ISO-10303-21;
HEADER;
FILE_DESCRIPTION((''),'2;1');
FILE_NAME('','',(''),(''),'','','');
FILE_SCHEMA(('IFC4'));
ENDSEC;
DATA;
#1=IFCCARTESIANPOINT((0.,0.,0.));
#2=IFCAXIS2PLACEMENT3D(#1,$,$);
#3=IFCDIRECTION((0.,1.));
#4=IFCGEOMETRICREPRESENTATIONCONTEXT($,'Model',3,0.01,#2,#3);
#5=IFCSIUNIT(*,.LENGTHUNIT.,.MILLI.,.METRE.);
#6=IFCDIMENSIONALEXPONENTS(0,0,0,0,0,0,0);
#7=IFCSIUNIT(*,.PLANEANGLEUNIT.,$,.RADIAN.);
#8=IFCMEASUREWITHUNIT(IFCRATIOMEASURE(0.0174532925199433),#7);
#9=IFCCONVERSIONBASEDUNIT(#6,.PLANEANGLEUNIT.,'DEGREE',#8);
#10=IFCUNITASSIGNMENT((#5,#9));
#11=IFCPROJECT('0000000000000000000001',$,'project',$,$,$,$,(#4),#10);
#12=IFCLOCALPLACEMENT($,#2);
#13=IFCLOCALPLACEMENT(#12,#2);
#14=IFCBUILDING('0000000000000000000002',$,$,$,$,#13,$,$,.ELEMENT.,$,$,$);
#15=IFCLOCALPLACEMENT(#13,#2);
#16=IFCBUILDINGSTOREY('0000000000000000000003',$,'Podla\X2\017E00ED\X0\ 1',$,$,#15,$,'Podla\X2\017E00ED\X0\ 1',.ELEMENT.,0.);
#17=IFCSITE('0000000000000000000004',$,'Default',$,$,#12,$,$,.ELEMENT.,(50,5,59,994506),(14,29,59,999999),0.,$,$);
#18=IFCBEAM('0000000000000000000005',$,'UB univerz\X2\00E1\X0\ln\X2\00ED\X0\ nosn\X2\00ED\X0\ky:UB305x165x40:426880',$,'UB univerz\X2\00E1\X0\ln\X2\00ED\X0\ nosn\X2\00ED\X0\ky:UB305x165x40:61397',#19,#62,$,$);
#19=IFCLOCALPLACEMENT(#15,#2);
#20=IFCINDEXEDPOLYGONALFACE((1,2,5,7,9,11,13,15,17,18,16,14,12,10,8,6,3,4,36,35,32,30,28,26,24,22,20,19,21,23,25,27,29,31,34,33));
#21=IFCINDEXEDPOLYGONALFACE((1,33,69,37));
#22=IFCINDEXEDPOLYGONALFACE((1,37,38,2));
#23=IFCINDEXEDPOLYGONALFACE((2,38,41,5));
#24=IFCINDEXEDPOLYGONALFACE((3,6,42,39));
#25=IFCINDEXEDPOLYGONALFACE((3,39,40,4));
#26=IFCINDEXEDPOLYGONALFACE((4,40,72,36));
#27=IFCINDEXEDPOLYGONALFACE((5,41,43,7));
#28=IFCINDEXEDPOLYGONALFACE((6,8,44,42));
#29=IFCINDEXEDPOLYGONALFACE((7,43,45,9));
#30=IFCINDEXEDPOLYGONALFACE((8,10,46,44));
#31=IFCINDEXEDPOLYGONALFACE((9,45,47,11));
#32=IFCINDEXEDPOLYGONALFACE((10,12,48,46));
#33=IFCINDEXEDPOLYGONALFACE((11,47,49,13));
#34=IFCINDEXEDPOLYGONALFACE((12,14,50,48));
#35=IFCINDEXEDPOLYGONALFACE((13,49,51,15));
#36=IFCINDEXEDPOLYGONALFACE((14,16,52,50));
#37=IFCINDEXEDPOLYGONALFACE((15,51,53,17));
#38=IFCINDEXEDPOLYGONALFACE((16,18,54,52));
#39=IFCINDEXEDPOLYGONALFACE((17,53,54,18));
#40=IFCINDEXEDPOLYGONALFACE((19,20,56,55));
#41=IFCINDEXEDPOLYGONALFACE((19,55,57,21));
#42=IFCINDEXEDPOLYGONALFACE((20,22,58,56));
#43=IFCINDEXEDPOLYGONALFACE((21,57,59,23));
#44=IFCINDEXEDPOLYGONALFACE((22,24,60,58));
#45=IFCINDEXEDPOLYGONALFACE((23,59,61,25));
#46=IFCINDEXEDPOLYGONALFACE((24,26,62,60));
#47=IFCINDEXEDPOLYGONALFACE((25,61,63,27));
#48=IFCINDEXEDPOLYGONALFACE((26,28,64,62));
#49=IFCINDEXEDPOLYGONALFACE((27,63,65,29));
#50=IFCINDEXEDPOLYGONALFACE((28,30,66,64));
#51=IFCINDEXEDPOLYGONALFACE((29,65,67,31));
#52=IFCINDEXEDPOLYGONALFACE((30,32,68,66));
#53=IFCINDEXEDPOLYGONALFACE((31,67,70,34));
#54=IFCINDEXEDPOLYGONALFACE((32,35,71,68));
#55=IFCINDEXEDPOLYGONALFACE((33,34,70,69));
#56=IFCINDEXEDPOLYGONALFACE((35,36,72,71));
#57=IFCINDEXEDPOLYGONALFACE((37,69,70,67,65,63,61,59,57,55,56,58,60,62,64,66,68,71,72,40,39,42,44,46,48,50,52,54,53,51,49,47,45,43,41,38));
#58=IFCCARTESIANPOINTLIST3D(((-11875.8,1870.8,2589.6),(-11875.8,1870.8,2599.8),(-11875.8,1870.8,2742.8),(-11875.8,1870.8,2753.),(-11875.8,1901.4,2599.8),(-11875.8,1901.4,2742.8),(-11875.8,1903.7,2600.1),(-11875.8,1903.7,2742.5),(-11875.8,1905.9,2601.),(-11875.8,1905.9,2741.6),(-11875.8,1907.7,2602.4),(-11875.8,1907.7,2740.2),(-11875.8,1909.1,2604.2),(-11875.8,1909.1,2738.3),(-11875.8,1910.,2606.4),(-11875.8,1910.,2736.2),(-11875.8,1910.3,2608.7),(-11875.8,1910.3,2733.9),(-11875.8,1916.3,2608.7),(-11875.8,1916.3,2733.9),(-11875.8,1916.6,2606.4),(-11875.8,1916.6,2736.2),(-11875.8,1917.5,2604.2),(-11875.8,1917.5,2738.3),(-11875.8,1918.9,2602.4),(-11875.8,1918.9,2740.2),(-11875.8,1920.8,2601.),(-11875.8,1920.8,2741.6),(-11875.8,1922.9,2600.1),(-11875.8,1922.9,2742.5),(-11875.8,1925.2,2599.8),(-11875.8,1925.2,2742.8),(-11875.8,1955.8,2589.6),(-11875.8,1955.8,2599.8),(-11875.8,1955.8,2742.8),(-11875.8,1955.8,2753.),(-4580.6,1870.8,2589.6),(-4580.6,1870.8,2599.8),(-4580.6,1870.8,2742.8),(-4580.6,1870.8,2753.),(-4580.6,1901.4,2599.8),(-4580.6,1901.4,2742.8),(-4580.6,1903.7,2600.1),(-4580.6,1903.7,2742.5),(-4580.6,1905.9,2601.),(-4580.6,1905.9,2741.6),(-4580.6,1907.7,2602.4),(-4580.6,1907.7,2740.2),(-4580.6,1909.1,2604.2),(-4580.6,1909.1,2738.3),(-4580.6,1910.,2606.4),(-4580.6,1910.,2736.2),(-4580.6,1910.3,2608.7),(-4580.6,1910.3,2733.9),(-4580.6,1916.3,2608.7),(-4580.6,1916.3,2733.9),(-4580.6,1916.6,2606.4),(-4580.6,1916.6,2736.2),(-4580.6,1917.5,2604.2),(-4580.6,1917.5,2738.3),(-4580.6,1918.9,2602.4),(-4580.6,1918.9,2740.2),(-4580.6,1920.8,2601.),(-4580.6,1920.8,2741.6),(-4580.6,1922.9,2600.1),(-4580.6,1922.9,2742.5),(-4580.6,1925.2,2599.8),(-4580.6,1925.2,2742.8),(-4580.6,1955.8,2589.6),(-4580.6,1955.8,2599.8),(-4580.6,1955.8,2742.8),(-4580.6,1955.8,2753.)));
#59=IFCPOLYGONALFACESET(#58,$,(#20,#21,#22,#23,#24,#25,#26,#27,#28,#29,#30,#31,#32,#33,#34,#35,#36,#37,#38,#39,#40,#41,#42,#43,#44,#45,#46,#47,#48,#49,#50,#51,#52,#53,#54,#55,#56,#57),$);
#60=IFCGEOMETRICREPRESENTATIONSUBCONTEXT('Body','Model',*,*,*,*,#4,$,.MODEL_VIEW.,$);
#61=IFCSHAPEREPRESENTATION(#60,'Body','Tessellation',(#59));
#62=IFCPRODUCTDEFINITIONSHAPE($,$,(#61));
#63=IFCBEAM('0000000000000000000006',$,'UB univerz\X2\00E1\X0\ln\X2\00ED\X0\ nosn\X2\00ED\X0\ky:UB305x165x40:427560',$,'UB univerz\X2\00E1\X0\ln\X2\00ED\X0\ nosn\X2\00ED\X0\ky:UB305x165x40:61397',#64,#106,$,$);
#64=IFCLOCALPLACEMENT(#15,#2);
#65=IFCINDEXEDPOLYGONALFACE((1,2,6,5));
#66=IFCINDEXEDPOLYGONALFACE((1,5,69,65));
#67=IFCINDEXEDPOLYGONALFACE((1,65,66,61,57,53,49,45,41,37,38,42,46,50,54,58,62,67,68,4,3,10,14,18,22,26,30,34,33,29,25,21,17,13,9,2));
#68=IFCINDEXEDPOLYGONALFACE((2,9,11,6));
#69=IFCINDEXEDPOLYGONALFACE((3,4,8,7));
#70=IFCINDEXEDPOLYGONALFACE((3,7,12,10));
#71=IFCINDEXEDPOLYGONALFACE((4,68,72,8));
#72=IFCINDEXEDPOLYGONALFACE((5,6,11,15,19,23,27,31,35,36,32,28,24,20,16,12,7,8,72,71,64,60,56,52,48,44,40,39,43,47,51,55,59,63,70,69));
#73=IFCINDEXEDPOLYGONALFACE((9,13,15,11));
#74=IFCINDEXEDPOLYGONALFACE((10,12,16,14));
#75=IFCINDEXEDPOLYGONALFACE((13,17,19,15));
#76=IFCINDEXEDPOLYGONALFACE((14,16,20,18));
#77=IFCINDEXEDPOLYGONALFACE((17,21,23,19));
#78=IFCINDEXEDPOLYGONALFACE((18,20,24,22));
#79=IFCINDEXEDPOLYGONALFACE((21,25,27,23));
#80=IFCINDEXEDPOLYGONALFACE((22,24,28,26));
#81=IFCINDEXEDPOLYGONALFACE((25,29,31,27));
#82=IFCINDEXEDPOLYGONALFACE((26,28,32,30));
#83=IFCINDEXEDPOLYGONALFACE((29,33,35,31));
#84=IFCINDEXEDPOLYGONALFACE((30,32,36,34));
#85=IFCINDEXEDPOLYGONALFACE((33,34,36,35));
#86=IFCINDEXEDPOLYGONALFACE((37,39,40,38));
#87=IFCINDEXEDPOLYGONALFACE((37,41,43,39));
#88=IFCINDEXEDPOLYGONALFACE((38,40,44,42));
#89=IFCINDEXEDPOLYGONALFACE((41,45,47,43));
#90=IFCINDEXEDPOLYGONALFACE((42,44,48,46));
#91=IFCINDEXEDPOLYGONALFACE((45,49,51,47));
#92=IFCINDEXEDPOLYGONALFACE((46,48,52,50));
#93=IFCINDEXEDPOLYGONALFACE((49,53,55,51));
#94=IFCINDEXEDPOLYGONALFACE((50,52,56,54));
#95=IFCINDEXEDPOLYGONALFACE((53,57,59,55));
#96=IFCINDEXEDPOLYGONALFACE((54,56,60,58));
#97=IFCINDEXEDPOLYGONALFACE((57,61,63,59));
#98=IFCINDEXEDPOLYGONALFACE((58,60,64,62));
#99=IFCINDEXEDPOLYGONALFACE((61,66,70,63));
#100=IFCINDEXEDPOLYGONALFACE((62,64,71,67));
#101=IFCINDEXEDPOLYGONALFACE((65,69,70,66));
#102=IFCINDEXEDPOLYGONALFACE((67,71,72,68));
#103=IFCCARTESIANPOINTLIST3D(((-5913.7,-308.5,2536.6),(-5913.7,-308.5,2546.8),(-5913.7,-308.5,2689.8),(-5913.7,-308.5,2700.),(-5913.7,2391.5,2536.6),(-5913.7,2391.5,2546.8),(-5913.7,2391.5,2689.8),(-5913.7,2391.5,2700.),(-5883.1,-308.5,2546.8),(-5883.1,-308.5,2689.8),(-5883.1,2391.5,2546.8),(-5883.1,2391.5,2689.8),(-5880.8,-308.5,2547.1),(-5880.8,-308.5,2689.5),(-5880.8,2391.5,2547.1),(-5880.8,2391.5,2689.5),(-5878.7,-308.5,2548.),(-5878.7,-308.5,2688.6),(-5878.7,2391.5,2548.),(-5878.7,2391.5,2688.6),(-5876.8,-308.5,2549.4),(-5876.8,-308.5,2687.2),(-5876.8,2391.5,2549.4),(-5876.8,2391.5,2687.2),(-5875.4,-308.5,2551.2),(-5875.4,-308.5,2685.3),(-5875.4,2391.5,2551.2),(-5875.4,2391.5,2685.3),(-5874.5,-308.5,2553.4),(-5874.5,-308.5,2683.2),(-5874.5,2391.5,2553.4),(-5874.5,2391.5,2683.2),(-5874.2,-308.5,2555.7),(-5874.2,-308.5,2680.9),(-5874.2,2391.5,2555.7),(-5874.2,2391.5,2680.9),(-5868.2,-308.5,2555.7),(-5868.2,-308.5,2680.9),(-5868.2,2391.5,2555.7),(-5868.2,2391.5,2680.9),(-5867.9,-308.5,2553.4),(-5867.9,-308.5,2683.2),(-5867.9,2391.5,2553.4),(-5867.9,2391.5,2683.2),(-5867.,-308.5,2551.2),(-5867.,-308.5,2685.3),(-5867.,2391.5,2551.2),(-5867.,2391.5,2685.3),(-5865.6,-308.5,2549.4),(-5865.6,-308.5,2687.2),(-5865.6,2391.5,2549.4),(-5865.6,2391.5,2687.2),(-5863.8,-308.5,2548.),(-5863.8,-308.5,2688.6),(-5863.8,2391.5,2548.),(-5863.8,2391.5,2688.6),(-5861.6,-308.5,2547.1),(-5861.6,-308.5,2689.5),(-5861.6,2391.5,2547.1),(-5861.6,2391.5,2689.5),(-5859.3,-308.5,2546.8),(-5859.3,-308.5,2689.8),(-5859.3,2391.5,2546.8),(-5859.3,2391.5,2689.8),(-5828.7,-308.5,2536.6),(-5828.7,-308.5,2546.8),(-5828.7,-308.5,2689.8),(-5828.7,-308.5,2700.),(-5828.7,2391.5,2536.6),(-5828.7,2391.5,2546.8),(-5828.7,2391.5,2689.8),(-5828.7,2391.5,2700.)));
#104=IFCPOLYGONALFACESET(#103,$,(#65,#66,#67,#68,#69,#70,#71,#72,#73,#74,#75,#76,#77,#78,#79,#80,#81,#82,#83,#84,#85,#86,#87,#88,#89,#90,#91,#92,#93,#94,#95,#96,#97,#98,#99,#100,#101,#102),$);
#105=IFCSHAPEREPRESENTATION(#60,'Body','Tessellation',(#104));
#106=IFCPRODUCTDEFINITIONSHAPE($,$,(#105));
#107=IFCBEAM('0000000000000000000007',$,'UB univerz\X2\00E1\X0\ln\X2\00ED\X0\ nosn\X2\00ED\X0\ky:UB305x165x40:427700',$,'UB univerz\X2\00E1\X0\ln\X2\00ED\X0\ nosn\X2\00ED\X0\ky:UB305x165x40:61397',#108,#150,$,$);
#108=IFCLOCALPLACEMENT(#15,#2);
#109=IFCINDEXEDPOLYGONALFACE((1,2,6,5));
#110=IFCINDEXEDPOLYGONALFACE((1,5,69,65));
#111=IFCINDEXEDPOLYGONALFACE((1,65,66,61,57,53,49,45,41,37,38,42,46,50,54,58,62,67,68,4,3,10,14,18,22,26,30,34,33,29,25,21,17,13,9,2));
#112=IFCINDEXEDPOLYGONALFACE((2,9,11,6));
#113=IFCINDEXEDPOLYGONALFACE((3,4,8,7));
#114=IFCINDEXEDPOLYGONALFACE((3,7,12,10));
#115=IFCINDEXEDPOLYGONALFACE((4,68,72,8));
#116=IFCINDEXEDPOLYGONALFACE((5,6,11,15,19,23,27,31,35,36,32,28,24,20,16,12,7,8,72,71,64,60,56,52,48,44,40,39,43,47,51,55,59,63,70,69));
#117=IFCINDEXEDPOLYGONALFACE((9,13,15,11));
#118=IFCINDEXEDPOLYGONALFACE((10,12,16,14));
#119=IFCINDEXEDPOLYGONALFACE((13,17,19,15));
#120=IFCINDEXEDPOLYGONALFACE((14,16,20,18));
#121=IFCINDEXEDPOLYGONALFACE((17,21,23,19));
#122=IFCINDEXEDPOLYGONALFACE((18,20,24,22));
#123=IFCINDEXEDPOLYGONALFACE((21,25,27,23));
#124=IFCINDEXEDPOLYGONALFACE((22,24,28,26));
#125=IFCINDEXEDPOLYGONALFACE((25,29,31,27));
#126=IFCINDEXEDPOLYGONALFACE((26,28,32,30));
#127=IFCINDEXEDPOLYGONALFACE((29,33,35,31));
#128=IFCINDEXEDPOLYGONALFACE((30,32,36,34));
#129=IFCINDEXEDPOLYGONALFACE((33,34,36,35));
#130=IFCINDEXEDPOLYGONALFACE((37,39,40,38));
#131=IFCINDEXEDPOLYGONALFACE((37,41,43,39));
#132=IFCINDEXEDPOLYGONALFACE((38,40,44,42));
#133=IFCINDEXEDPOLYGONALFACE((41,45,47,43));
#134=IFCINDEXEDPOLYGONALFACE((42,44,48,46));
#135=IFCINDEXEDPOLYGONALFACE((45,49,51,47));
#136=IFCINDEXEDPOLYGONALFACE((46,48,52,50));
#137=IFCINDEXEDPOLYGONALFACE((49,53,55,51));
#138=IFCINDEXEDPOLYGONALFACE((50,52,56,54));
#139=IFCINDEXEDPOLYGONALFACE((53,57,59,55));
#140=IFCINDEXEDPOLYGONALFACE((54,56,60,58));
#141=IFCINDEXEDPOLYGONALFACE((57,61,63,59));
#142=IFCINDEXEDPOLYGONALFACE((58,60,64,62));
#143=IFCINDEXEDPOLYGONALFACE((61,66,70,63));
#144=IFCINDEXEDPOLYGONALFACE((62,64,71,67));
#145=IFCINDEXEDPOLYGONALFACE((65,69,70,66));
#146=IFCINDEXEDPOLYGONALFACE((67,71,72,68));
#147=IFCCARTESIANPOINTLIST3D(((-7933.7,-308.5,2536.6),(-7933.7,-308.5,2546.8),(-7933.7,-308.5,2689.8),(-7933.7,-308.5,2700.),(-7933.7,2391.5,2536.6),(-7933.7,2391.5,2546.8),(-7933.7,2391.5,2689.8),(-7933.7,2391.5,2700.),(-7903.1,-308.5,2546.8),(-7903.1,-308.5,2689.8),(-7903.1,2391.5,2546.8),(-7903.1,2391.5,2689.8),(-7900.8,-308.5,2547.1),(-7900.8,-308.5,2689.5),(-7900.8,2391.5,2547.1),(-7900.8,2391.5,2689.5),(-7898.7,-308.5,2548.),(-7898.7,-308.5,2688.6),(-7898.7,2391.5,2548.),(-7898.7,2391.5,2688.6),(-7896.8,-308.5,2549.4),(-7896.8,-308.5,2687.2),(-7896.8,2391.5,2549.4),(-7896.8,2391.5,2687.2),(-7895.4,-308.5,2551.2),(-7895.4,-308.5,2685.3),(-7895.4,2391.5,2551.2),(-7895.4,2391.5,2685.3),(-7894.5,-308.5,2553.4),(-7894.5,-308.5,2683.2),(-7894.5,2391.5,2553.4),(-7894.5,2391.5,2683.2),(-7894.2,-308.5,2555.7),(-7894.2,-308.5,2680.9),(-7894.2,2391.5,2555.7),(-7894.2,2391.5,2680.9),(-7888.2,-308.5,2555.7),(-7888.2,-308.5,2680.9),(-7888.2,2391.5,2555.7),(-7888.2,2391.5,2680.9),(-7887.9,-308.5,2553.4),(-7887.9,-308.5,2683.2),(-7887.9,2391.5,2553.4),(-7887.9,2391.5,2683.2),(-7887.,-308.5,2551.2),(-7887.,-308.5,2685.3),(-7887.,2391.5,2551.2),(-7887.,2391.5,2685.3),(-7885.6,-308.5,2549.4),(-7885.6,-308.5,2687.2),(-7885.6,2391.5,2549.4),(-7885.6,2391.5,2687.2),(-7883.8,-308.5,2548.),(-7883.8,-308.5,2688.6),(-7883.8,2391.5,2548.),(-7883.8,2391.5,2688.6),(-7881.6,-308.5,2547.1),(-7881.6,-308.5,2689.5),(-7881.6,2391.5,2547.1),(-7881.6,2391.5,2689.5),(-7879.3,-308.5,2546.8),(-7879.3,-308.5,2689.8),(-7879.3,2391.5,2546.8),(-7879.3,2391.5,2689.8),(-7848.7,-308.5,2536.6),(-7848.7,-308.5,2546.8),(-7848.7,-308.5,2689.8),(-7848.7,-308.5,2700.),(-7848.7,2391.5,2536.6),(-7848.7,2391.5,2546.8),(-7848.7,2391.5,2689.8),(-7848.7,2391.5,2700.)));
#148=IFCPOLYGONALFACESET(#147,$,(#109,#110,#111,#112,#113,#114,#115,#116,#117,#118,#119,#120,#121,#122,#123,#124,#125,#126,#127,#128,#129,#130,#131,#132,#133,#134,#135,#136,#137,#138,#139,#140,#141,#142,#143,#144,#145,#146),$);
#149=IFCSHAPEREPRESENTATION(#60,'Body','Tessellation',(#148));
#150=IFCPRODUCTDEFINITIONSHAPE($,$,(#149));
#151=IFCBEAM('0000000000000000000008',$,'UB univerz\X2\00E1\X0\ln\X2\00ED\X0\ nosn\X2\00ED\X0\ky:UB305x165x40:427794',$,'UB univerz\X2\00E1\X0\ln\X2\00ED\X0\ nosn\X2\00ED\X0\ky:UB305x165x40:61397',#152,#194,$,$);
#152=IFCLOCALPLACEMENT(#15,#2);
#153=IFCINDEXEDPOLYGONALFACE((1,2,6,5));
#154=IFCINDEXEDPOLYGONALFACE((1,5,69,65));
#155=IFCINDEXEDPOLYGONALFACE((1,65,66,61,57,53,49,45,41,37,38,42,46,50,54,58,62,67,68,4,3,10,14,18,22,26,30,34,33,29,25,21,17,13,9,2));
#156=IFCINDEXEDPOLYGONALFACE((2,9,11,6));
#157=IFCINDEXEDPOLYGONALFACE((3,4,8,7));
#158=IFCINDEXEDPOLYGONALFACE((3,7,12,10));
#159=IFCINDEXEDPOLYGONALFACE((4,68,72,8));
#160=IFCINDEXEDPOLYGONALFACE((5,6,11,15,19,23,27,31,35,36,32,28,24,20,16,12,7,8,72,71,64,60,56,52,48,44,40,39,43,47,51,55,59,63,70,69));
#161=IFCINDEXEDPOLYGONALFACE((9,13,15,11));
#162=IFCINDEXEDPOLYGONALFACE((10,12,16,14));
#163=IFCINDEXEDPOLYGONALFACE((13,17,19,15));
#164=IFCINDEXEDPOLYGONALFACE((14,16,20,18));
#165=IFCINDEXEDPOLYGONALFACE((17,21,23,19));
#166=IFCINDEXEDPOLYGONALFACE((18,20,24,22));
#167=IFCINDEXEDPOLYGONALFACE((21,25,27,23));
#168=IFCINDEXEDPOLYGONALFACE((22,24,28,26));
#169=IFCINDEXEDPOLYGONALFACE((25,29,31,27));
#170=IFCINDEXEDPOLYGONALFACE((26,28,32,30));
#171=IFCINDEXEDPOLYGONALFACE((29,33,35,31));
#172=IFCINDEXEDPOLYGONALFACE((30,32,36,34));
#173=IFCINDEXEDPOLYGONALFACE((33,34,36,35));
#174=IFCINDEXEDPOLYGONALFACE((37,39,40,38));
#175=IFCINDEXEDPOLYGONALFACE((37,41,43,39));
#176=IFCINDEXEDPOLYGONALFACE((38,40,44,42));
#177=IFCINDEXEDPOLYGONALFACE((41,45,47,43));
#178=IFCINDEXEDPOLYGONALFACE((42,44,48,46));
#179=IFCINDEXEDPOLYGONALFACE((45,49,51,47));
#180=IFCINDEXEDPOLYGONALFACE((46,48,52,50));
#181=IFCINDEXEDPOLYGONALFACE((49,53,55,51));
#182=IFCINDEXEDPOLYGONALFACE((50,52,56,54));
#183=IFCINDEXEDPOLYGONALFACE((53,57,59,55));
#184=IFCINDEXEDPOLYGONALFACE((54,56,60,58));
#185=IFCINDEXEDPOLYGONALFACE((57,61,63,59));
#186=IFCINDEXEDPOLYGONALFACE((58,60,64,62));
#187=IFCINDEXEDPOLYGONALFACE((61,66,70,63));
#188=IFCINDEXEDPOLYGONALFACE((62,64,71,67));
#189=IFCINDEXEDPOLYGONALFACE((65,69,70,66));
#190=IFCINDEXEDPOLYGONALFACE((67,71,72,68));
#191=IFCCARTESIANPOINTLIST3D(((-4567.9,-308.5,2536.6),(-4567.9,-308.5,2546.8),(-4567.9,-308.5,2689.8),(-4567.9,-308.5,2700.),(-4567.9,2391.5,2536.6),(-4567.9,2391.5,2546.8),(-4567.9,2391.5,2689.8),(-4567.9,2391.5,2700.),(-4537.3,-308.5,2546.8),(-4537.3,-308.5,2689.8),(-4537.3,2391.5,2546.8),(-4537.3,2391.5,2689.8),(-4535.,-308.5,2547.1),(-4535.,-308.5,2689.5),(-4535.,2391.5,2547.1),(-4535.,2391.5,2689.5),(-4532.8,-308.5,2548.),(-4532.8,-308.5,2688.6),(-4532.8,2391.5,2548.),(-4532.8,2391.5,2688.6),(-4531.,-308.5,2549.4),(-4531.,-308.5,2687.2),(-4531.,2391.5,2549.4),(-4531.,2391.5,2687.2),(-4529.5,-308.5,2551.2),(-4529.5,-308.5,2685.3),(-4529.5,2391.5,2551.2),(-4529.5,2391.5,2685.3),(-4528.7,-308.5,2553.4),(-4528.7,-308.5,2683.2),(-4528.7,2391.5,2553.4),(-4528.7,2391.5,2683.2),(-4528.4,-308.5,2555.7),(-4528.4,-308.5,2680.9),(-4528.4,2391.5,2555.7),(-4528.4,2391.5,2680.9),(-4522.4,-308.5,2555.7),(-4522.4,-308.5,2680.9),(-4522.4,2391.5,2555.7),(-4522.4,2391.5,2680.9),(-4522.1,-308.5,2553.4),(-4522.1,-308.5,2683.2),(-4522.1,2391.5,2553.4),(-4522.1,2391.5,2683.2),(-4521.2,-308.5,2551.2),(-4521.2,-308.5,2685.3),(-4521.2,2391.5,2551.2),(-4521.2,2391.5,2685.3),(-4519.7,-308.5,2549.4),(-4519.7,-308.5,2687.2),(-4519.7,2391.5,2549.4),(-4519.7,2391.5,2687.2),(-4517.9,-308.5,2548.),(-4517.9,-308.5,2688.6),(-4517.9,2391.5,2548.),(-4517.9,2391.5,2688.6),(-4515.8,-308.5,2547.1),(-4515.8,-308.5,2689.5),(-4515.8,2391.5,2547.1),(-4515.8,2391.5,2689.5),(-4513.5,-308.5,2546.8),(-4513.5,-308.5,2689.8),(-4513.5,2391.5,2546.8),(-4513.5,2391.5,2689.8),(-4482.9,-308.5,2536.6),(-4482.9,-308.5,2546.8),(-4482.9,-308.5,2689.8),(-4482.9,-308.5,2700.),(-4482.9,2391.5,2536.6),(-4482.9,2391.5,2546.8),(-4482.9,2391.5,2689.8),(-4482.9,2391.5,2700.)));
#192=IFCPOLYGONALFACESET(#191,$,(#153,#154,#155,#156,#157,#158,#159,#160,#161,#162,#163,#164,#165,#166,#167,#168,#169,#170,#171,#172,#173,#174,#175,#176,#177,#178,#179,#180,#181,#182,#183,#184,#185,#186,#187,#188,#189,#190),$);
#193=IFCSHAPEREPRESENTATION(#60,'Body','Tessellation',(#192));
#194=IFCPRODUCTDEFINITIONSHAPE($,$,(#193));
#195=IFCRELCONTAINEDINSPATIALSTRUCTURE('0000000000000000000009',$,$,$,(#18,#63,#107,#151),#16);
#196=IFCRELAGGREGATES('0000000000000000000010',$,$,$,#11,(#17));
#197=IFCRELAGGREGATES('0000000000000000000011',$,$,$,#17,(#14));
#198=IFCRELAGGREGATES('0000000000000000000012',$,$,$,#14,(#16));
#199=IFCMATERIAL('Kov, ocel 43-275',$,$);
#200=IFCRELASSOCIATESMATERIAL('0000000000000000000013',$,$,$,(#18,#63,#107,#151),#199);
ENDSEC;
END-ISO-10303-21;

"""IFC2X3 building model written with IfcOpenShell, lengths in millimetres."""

from ifc_helpers import new_model, entity, si_unit, converted_unit, direction, frame, frame_2d, origin, place, context, subcontext, project, spatial, i_section, extrude, material, element, save


model = new_model("IFC2X3")

# Units and contexts
model_context = context("Model", 3, precision=0.01, world=origin(), true_north=direction((0.0, 1.0)))
body_context = subcontext(model_context, "Body", "Model", "MODEL_VIEW")
ifc_project = project(units=[si_unit("LENGTHUNIT", "METRE", prefix="MILLI"), converted_unit("PLANEANGLEUNIT", "DEGREE", entity("IfcRatioMeasure", 0.0174532925199433), si_unit("PLANEANGLEUNIT", "RADIAN"), dimensions=[0, 0, 0, 0, 0, 0, 0])], contexts=[model_context])

# Site, building, storey
site_placement = place(None, origin())
site = spatial("IfcSite", under=ifc_project, at=site_placement, Name="Default", CompositionType="ELEMENT", RefLatitude=(50, 5, 59, 994506), RefLongitude=(14, 29, 59, 999999), RefElevation=0.0)
building_placement = place(site_placement, origin())
building = spatial("IfcBuilding", under=site, at=building_placement, CompositionType="ELEMENT")
storey_placement = place(building_placement, origin())
storey = spatial("IfcBuildingStorey", under=building, at=storey_placement, Name="Podlaží 1", LongName="Podlaží 1", CompositionType="ELEMENT", Elevation=0.0)

# Shared definitions
ifc_material = material(Name="Kov, ocel 43-275")

# Beams
beam_1_placement = place(storey_placement, frame((-4525.4, 1913.3, 0.0), z_axis=(0.0, 0.0, 1.0), x_axis=(-1.0, 0.0, 0.0)))
element("IfcBeam", 1, at=beam_1_placement, inside=storey, material=ifc_material, Name="UB univerzální nosníky:UB305x165x40:426880", ObjectType="UB univerzální nosníky:UB305x165x40:61397", context=body_context, shape_type="SweptSolid", body=[
    extrude(i_section(OverallWidth=85.0, OverallDepth=163.4, WebThickness=6.0, FlangeThickness=10.2, FilletRadius=8.9, at=frame_2d((0.0, 0.0), x_axis=(0.0, 1.0))), frame((55.2, 0.0, 2671.3), z_axis=(1.0, 0.0, 0.0), x_axis=(0.0, 0.0, -1.0)), (0.0, 0.0, 1.0), 7295.2),
])
beam_2_placement = place(storey_placement, frame((-5871.2, -308.5, 0.0), z_axis=(0.0, 0.0, 1.0), x_axis=(0.0, 1.0, 0.0)))
element("IfcBeam", 2, at=beam_2_placement, inside=storey, material=ifc_material, Name="UB univerzální nosníky:UB305x165x40:427560", ObjectType="UB univerzální nosníky:UB305x165x40:61397", context=body_context, shape_type="SweptSolid", body=[
    extrude(i_section(OverallWidth=85.0, OverallDepth=163.4, WebThickness=6.0, FlangeThickness=10.2, FilletRadius=8.9, at=frame_2d((0.0, 0.0), x_axis=(0.0, 1.0))), frame((0.0, 0.0, 2618.3), z_axis=(1.0, 0.0, 0.0), x_axis=(0.0, 0.0, -1.0)), (0.0, 0.0, 1.0), 2700.0),
])
beam_3_placement = place(storey_placement, frame((-7891.2, -308.5, 0.0), z_axis=(0.0, 0.0, 1.0), x_axis=(0.0, 1.0, 0.0)))
element("IfcBeam", 3, at=beam_3_placement, inside=storey, material=ifc_material, Name="UB univerzální nosníky:UB305x165x40:427700", ObjectType="UB univerzální nosníky:UB305x165x40:61397", context=body_context, shape_type="SweptSolid", body=[
    extrude(i_section(OverallWidth=85.0, OverallDepth=163.4, WebThickness=6.0, FlangeThickness=10.2, FilletRadius=8.9, at=frame_2d((0.0, 0.0), x_axis=(0.0, 1.0))), frame((0.0, 0.0, 2618.3), z_axis=(1.0, 0.0, 0.0), x_axis=(0.0, 0.0, -1.0)), (0.0, 0.0, 1.0), 2700.0),
])
beam_4_placement = place(storey_placement, frame((-4525.4, -308.5, 0.0), z_axis=(0.0, 0.0, 1.0), x_axis=(0.0, 1.0, 0.0)))
element("IfcBeam", 4, at=beam_4_placement, inside=storey, material=ifc_material, Name="UB univerzální nosníky:UB305x165x40:427794", ObjectType="UB univerzální nosníky:UB305x165x40:61397", context=body_context, shape_type="SweptSolid", body=[
    extrude(i_section(OverallWidth=85.0, OverallDepth=163.4, WebThickness=6.0, FlangeThickness=10.2, FilletRadius=8.9, at=frame_2d((0.0, 0.0), x_axis=(0.0, 1.0))), frame((0.0, 0.0, 2618.3), z_axis=(1.0, 0.0, 0.0), x_axis=(0.0, 0.0, -1.0)), (0.0, 0.0, 1.0), 2700.0),
])

save(model, "model.ifc")
